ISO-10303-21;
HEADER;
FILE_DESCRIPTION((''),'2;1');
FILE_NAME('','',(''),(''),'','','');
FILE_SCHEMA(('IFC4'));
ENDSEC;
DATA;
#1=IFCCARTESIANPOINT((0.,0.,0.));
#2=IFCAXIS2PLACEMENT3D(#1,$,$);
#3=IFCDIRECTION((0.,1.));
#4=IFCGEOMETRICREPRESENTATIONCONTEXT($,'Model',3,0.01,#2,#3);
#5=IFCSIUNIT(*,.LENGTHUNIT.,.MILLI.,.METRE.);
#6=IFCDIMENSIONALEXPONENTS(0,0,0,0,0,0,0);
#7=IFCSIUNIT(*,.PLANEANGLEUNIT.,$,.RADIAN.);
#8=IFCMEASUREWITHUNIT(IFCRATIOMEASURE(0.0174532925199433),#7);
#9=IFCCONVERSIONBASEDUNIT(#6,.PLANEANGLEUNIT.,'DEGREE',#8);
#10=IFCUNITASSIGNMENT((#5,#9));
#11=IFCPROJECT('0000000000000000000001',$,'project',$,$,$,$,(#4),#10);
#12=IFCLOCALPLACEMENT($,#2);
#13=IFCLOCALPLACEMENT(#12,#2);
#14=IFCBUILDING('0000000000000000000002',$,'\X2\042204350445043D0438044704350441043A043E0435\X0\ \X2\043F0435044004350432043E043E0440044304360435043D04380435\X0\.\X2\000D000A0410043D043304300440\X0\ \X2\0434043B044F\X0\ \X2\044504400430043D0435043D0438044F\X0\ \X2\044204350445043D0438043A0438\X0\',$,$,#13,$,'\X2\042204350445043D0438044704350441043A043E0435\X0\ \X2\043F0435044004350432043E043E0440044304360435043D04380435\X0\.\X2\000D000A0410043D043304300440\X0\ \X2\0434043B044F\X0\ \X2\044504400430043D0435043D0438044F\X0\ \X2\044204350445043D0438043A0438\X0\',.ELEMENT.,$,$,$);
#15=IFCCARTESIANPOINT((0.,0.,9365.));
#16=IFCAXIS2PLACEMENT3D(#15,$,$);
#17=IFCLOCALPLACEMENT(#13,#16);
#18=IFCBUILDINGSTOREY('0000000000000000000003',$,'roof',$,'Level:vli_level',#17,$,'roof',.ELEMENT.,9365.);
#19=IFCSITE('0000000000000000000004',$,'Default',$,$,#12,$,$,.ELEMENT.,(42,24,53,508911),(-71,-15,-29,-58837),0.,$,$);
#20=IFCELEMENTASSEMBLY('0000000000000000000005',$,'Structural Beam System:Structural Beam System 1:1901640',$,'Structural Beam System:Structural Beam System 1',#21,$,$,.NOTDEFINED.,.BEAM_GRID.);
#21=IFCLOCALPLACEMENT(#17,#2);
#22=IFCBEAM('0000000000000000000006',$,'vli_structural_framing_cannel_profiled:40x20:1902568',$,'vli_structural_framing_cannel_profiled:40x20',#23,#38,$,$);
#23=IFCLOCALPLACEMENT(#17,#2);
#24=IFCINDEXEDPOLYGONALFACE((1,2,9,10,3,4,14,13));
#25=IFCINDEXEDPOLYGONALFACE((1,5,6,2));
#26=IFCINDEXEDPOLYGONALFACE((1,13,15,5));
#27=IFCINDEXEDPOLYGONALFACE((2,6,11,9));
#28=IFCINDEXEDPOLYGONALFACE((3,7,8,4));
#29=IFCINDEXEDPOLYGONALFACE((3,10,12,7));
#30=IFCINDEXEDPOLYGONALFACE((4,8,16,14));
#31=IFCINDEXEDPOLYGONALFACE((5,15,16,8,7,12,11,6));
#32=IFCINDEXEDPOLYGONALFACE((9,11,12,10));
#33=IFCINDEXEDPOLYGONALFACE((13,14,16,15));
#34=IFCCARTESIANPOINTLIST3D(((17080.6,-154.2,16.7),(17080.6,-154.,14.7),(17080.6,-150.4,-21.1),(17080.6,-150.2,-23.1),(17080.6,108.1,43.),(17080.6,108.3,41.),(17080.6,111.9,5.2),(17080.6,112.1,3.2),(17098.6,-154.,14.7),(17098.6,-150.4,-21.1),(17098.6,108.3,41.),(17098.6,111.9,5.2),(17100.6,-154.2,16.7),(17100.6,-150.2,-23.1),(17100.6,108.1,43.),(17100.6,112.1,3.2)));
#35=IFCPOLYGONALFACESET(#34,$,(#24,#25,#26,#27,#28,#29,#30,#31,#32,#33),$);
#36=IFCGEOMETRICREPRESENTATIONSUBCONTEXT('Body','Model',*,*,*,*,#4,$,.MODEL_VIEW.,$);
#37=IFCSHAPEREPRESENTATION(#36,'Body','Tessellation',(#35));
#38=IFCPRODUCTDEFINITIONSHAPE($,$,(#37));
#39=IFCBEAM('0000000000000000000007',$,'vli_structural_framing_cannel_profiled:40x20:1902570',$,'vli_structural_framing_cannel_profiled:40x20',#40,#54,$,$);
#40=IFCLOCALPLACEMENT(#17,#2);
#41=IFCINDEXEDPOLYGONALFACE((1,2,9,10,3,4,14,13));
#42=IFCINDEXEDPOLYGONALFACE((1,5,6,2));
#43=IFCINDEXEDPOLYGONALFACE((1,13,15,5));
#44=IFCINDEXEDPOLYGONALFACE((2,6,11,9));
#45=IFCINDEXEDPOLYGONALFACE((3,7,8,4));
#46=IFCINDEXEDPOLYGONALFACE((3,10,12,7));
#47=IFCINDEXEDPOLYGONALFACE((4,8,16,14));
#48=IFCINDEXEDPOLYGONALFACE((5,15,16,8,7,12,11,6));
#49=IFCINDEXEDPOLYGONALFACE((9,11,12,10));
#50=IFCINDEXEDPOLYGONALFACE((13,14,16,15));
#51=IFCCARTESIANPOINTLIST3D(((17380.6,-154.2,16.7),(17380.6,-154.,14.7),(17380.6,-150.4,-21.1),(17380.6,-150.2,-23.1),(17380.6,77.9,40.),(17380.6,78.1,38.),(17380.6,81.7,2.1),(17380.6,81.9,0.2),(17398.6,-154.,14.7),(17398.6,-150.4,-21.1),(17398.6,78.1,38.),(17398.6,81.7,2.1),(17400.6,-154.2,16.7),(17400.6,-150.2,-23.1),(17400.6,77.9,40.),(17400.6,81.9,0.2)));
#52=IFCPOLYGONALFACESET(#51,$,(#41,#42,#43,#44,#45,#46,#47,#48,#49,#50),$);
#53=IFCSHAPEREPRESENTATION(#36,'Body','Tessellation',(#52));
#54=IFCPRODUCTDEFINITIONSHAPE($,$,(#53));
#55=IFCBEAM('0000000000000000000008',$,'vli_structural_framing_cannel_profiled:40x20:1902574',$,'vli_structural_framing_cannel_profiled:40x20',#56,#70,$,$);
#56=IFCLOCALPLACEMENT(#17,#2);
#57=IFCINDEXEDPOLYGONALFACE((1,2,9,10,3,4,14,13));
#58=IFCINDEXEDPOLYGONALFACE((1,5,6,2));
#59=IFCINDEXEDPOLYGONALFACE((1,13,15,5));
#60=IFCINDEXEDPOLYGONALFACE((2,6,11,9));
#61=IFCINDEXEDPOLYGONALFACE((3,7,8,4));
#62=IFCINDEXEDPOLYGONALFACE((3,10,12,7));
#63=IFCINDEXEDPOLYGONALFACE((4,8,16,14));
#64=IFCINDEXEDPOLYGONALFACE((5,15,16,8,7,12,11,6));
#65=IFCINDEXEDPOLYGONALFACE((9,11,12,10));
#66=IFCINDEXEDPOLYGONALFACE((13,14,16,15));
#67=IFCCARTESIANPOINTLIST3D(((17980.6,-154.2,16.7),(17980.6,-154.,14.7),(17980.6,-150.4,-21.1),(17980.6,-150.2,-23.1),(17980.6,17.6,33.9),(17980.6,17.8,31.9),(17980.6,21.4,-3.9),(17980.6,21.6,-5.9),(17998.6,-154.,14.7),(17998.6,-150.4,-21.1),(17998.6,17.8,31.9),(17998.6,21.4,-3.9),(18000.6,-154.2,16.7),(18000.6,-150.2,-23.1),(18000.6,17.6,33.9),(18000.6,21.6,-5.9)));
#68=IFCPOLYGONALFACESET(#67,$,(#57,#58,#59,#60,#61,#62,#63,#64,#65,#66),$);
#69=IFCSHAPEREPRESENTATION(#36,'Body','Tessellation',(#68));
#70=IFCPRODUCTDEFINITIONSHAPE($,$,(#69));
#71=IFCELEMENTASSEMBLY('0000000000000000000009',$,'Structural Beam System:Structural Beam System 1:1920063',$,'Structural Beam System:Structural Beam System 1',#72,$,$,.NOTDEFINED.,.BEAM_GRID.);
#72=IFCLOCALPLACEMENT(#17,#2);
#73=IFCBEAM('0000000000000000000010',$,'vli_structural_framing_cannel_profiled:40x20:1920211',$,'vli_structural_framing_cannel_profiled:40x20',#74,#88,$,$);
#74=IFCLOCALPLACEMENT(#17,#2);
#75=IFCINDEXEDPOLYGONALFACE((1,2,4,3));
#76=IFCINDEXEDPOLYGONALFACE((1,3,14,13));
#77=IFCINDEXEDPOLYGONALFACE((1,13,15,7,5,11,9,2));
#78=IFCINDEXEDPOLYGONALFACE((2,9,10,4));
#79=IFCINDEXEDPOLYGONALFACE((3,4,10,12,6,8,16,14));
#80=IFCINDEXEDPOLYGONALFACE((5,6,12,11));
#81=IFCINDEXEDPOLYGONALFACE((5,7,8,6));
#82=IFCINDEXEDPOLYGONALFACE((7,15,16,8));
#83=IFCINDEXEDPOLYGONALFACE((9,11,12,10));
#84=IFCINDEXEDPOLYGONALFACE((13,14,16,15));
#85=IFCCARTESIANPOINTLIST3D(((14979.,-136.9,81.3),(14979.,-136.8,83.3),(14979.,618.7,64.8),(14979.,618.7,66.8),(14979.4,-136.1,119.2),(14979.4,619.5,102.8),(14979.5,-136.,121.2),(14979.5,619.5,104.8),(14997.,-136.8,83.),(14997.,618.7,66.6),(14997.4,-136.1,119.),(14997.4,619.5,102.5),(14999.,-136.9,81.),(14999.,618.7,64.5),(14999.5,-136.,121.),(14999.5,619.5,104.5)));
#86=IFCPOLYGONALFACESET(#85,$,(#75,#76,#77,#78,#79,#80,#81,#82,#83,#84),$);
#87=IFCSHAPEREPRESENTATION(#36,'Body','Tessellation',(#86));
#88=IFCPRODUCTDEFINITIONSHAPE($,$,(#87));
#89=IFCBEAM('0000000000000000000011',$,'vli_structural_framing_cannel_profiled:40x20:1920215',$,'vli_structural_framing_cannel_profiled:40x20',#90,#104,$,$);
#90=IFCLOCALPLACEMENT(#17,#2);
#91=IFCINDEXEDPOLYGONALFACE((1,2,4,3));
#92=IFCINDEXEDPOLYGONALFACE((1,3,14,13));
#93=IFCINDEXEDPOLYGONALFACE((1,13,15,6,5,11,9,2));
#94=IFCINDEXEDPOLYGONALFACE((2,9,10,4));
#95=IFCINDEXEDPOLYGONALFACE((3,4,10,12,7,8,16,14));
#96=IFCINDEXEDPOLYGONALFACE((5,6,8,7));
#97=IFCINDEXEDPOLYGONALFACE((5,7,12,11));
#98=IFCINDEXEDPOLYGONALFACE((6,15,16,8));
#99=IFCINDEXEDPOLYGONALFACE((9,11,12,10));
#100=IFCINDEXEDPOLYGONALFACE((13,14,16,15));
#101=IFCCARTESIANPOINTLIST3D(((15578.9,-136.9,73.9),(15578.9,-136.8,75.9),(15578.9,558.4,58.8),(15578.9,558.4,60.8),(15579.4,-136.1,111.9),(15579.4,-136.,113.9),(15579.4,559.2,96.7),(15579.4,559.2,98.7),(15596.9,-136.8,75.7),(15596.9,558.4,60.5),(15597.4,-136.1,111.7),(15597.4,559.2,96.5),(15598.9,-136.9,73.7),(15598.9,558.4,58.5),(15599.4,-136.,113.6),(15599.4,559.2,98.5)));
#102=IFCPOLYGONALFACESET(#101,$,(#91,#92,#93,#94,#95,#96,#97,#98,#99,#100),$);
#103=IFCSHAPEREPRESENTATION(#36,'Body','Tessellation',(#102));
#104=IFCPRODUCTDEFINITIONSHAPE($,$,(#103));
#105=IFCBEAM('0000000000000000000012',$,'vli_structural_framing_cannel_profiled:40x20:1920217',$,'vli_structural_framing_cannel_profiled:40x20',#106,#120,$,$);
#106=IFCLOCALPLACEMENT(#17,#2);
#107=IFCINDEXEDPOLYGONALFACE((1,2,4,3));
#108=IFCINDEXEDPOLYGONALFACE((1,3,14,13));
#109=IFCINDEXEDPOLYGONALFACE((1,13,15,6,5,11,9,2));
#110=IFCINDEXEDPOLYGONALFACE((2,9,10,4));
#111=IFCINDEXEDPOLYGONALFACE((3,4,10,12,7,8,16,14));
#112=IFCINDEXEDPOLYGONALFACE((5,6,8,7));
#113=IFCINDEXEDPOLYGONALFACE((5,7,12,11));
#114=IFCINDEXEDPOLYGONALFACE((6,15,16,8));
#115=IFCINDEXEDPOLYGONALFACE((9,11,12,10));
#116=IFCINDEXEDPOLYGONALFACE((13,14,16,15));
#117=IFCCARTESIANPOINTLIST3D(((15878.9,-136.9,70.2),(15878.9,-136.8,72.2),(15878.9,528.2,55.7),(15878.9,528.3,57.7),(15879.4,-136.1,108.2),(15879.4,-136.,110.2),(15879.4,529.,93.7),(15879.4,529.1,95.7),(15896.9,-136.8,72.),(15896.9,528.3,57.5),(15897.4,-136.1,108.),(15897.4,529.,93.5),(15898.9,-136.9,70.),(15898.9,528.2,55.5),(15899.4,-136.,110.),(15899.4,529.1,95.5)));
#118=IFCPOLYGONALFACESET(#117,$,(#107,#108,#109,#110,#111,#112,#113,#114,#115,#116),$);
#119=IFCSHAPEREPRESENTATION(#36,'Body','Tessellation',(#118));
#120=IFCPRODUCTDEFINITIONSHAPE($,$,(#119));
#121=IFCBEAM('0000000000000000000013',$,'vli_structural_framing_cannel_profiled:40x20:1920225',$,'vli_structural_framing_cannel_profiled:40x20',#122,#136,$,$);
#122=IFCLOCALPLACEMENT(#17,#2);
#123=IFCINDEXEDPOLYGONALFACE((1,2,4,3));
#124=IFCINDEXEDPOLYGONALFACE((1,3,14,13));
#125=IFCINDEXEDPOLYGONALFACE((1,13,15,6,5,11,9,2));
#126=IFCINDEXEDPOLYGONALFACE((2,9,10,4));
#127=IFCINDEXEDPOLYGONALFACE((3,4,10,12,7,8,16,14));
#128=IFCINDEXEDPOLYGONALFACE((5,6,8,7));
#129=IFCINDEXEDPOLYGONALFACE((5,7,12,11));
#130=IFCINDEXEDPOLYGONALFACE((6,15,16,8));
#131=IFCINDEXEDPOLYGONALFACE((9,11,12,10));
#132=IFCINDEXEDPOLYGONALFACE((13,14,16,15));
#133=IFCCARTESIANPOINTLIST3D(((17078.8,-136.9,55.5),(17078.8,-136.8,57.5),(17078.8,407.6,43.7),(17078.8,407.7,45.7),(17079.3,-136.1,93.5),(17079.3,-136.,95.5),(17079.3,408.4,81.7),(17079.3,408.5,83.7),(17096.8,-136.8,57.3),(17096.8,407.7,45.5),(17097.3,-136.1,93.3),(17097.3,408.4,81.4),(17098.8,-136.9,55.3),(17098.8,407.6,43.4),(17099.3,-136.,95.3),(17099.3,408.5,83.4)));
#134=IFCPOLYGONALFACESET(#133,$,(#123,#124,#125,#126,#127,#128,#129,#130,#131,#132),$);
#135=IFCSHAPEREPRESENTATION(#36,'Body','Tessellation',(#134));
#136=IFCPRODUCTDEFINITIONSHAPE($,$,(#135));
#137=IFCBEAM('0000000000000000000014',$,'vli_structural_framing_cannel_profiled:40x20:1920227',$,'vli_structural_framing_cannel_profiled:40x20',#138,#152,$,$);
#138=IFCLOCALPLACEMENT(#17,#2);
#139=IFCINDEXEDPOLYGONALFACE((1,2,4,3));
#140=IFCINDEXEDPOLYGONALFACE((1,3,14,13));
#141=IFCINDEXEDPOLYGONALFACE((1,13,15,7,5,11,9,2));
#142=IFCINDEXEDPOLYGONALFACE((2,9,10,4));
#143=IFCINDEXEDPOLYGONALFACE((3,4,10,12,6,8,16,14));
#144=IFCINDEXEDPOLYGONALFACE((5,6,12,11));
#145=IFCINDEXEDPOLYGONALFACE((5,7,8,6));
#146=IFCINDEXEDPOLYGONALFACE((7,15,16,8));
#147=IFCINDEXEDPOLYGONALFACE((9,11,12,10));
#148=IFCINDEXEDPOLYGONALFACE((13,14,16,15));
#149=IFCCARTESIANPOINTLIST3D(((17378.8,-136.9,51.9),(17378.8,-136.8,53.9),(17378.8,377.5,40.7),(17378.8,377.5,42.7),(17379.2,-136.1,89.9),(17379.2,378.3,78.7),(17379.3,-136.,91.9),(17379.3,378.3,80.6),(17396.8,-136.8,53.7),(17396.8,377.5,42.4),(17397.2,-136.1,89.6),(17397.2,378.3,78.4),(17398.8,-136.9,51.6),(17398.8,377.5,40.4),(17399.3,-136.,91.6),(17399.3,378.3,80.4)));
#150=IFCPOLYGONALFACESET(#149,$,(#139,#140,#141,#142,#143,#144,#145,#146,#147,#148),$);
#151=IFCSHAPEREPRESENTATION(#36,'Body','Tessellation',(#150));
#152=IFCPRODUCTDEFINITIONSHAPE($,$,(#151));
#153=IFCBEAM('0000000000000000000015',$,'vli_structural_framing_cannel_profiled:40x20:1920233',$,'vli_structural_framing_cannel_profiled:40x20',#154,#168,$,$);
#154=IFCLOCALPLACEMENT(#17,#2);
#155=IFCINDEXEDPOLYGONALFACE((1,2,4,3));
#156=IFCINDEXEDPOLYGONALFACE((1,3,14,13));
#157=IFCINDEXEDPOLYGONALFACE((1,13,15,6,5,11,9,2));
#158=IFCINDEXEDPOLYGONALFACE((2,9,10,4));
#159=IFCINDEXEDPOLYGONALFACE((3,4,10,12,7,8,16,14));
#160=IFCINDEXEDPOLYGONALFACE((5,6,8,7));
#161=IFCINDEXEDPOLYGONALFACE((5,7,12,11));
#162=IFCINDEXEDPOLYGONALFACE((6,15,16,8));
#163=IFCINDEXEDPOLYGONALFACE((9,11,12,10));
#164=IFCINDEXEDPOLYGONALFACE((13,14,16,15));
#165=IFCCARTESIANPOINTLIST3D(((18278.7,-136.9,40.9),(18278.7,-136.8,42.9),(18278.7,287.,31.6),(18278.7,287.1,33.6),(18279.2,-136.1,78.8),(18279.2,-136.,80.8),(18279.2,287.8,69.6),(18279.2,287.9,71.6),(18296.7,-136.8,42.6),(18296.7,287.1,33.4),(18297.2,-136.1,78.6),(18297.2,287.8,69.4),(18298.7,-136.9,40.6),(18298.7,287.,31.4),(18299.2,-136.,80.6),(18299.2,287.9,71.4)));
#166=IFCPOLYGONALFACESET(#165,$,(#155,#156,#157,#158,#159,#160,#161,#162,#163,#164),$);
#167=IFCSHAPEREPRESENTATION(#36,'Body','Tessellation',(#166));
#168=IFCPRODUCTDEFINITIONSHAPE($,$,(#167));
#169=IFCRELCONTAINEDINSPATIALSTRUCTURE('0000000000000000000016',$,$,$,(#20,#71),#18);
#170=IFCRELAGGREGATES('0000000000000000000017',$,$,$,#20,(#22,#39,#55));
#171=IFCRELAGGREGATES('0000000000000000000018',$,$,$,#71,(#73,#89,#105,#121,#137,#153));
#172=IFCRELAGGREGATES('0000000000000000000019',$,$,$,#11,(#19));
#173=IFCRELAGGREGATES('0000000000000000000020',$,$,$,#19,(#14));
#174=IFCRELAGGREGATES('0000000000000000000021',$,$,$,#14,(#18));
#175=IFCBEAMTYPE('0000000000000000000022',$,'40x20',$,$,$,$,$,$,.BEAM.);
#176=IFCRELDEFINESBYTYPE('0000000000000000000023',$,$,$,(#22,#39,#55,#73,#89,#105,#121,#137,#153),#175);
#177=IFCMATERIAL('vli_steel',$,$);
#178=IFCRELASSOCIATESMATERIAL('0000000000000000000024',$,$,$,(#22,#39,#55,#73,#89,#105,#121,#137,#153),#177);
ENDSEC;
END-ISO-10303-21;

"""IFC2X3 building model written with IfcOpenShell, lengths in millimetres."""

from ifc_helpers import new_model, entity, si_unit, converted_unit, direction, frame, origin, place, context, subcontext, project, spatial, polyline, outline, extrude, material, type_object, element, aggregate, save


model = new_model("IFC2X3")

# Units and contexts
model_context = context("Model", 3, precision=0.01, world=origin(), true_north=direction((0.0, 1.0)))
body_context = subcontext(model_context, "Body", "Model", "MODEL_VIEW")
ifc_project = project(units=[si_unit("LENGTHUNIT", "METRE", prefix="MILLI"), converted_unit("PLANEANGLEUNIT", "DEGREE", entity("IfcRatioMeasure", 0.0174532925199433), si_unit("PLANEANGLEUNIT", "RADIAN"), dimensions=[0, 0, 0, 0, 0, 0, 0])], contexts=[model_context])

# Site, building, storey
site_placement = place(None, origin())
site = spatial("IfcSite", under=ifc_project, at=site_placement, Name="Default", CompositionType="ELEMENT", RefLatitude=(42, 24, 53, 508911), RefLongitude=(-71, -15, -29, -58837), RefElevation=0.0)
building_placement = place(site_placement, origin())
building = spatial("IfcBuilding", under=site, at=building_placement, Name="Техническое перевооружение.\r\nАнгар для хранения техники", LongName="Техническое перевооружение.\r\nАнгар для хранения техники", CompositionType="ELEMENT")
storey_placement = place(building_placement, frame((0.0, 0.0, 9365.0)))
storey = spatial("IfcBuildingStorey", under=building, at=storey_placement, Name="roof", ObjectType="Level:vli_level", LongName="roof", CompositionType="ELEMENT", Elevation=9365.0)

# Element assemblies, beams
assembly_1_placement = place(storey_placement, origin())
assembly_1 = element("IfcElementAssembly", 1, at=assembly_1_placement, inside=storey, Name="Structural Beam System:Structural Beam System 1:1901640", ObjectType="Structural Beam System:Structural Beam System 1", AssemblyPlace="NOTDEFINED", PredefinedType="BEAM_GRID")
ifc_material = material(Name="vli_steel")
beam_type = type_object("IfcBeamType", Name="40x20", PredefinedType="BEAM")
beam_1_placement = place(assembly_1_placement, frame((17100.0, 125.4, 4.5), z_axis=(0.0, -0.099504, 0.995037), x_axis=(0.0, -0.995037, -0.099504)))
beam_1 = element("IfcBeam", 2, at=beam_1_placement, type_object=beam_type, material=ifc_material, Name="vli_structural_framing_cannel_profiled:40x20:1902568", ObjectType="vli_structural_framing_cannel_profiled:40x20", context=body_context, shape_type="SweptSolid", body=[
    extrude(outline(polyline([(-20.0, -9.5), (-18.0, -9.5), (-18.0, 8.5), (18.0, 8.5), (18.0, -9.5), (20.0, -9.5), (20.0, 10.5), (-20.0, 10.5), (-20.0, -9.5)])), frame((13.4, -9.9, 20.0), z_axis=(1.0, 0.0, 0.0), x_axis=(0.0, 0.0, -1.0)), (0.0, 0.0, 1.0), 263.6),
])
beam_2_placement = place(assembly_1_placement, frame((17400.0, 95.2, 1.5), z_axis=(0.0, -0.099504, 0.995037), x_axis=(0.0, -0.995037, -0.099504)))
beam_2 = element("IfcBeam", 3, at=beam_2_placement, type_object=beam_type, material=ifc_material, Name="vli_structural_framing_cannel_profiled:40x20:1902570", ObjectType="vli_structural_framing_cannel_profiled:40x20", context=body_context, shape_type="SweptSolid", body=[
    extrude(outline(polyline([(-20.0, -9.5), (-18.0, -9.5), (-18.0, 8.5), (18.0, 8.5), (18.0, -9.5), (20.0, -9.5), (20.0, 10.5), (-20.0, 10.5), (-20.0, -9.5)])), frame((13.4, -9.9, 20.0), z_axis=(1.0, 0.0, 0.0), x_axis=(0.0, 0.0, -1.0)), (0.0, 0.0, 1.0), 233.3),
])
beam_3_placement = place(assembly_1_placement, frame((18000.0, 34.9, -4.5), z_axis=(0.0, -0.099504, 0.995037), x_axis=(0.0, -0.995037, -0.099504)))
beam_3 = element("IfcBeam", 4, at=beam_3_placement, type_object=beam_type, material=ifc_material, Name="vli_structural_framing_cannel_profiled:40x20:1902574", ObjectType="vli_structural_framing_cannel_profiled:40x20", context=body_context, shape_type="SweptSolid", body=[
    extrude(outline(polyline([(-20.0, -9.5), (-18.0, -9.5), (-18.0, 8.5), (18.0, 8.5), (18.0, -9.5), (20.0, -9.5), (20.0, 10.5), (-20.0, 10.5), (-20.0, -9.5)])), frame((13.4, -9.9, 20.0), z_axis=(1.0, 0.0, 0.0), x_axis=(0.0, 0.0, -1.0)), (0.0, 0.0, 1.0), 172.7),
])
aggregate(assembly_1, [beam_1, beam_2, beam_3])
assembly_2_placement = place(storey_placement, origin())
assembly_2 = element("IfcElementAssembly", 5, at=assembly_2_placement, inside=storey, Name="Structural Beam System:Structural Beam System 1:1920063", ObjectType="Structural Beam System:Structural Beam System 1", AssemblyPlace="NOTDEFINED", PredefinedType="BEAM_GRID")
beam_4_placement = place(assembly_2_placement, frame((14998.9, 632.9, 104.2), z_axis=(0.0, 0.021793, 0.999763), x_axis=(0.0, -0.999763, 0.021793)))
beam_4 = element("IfcBeam", 6, at=beam_4_placement, type_object=beam_type, material=ifc_material, Name="vli_structural_framing_cannel_profiled:40x20:1920211", ObjectType="vli_structural_framing_cannel_profiled:40x20", context=body_context, shape_type="SweptSolid", body=[
    extrude(outline(polyline([(-10.5, -20.0), (9.5, -20.0), (9.5, -18.0), (-8.5, -18.0), (-8.5, 18.0), (9.5, 18.0), (9.5, 20.0), (-10.5, 20.0), (-10.5, -20.0)])), frame((13.4, -10.1, -19.9), z_axis=(1.0, 0.0, 0.0), x_axis=(0.0, -0.999925, 0.012237)), (0.0, 0.0, 1.0), 755.7),
])
beam_5_placement = place(assembly_2_placement, frame((15598.8, 572.6, 98.2), z_axis=(0.0, 0.021793, 0.999763), x_axis=(0.0, -0.999763, 0.021793)))
beam_5 = element("IfcBeam", 7, at=beam_5_placement, type_object=beam_type, material=ifc_material, Name="vli_structural_framing_cannel_profiled:40x20:1920215", ObjectType="vli_structural_framing_cannel_profiled:40x20", context=body_context, shape_type="SweptSolid", body=[
    extrude(outline(polyline([(-10.5, -20.0), (9.5, -20.0), (9.5, -18.0), (-8.5, -18.0), (-8.5, 18.0), (9.5, 18.0), (9.5, 20.0), (-10.5, 20.0), (-10.5, -20.0)])), frame((13.4, -10.1, -19.9), z_axis=(1.0, 0.0, 0.0), x_axis=(0.0, -0.999925, 0.012237)), (0.0, 0.0, 1.0), 695.4),
])
beam_6_placement = place(assembly_2_placement, frame((15898.8, 542.4, 95.2), z_axis=(0.0, 0.021793, 0.999763), x_axis=(0.0, -0.999763, 0.021793)))
beam_6 = element("IfcBeam", 8, at=beam_6_placement, type_object=beam_type, material=ifc_material, Name="vli_structural_framing_cannel_profiled:40x20:1920217", ObjectType="vli_structural_framing_cannel_profiled:40x20", context=body_context, shape_type="SweptSolid", body=[
    extrude(outline(polyline([(-10.5, -20.0), (9.5, -20.0), (9.5, -18.0), (-8.5, -18.0), (-8.5, 18.0), (9.5, 18.0), (9.5, 20.0), (-10.5, 20.0), (-10.5, -20.0)])), frame((13.4, -10.1, -19.9), z_axis=(1.0, 0.0, 0.0), x_axis=(0.0, -0.999925, 0.012237)), (0.0, 0.0, 1.0), 665.3),
])
beam_7_placement = place(assembly_2_placement, frame((17098.7, 421.8, 83.1), z_axis=(0.0, 0.021793, 0.999763), x_axis=(0.0, -0.999763, 0.021793)))
beam_7 = element("IfcBeam", 9, at=beam_7_placement, type_object=beam_type, material=ifc_material, Name="vli_structural_framing_cannel_profiled:40x20:1920225", ObjectType="vli_structural_framing_cannel_profiled:40x20", context=body_context, shape_type="SweptSolid", body=[
    extrude(outline(polyline([(-10.5, -20.0), (9.5, -20.0), (9.5, -18.0), (-8.5, -18.0), (-8.5, 18.0), (9.5, 18.0), (9.5, 20.0), (-10.5, 20.0), (-10.5, -20.0)])), frame((13.4, -10.1, -19.9), z_axis=(1.0, 0.0, 0.0), x_axis=(0.0, -0.999925, 0.012237)), (0.0, 0.0, 1.0), 544.6),
])
beam_8_placement = place(assembly_2_placement, frame((17398.7, 391.7, 80.1), z_axis=(0.0, 0.021793, 0.999763), x_axis=(0.0, -0.999763, 0.021793)))
beam_8 = element("IfcBeam", 10, at=beam_8_placement, type_object=beam_type, material=ifc_material, Name="vli_structural_framing_cannel_profiled:40x20:1920227", ObjectType="vli_structural_framing_cannel_profiled:40x20", context=body_context, shape_type="SweptSolid", body=[
    extrude(outline(polyline([(-10.5, -20.0), (9.5, -20.0), (9.5, -18.0), (-8.5, -18.0), (-8.5, 18.0), (9.5, 18.0), (9.5, 20.0), (-10.5, 20.0), (-10.5, -20.0)])), frame((13.4, -10.1, -19.9), z_axis=(1.0, 0.0, 0.0), x_axis=(0.0, -0.999925, 0.012237)), (0.0, 0.0, 1.0), 514.5),
])
beam_9_placement = place(assembly_2_placement, frame((18298.6, 301.2, 71.1), z_axis=(0.0, 0.021793, 0.999763), x_axis=(0.0, -0.999763, 0.021793)))
beam_9 = element("IfcBeam", 11, at=beam_9_placement, type_object=beam_type, material=ifc_material, Name="vli_structural_framing_cannel_profiled:40x20:1920233", ObjectType="vli_structural_framing_cannel_profiled:40x20", context=body_context, shape_type="SweptSolid", body=[
    extrude(outline(polyline([(-10.5, -20.0), (9.5, -20.0), (9.5, -18.0), (-8.5, -18.0), (-8.5, 18.0), (9.5, 18.0), (9.5, 20.0), (-10.5, 20.0), (-10.5, -20.0)])), frame((13.4, -10.1, -19.9), z_axis=(1.0, 0.0, 0.0), x_axis=(0.0, -0.999925, 0.012237)), (0.0, 0.0, 1.0), 424.0),
])
aggregate(assembly_2, [beam_4, beam_5, beam_6, beam_7, beam_8, beam_9])

save(model, "model.ifc")
